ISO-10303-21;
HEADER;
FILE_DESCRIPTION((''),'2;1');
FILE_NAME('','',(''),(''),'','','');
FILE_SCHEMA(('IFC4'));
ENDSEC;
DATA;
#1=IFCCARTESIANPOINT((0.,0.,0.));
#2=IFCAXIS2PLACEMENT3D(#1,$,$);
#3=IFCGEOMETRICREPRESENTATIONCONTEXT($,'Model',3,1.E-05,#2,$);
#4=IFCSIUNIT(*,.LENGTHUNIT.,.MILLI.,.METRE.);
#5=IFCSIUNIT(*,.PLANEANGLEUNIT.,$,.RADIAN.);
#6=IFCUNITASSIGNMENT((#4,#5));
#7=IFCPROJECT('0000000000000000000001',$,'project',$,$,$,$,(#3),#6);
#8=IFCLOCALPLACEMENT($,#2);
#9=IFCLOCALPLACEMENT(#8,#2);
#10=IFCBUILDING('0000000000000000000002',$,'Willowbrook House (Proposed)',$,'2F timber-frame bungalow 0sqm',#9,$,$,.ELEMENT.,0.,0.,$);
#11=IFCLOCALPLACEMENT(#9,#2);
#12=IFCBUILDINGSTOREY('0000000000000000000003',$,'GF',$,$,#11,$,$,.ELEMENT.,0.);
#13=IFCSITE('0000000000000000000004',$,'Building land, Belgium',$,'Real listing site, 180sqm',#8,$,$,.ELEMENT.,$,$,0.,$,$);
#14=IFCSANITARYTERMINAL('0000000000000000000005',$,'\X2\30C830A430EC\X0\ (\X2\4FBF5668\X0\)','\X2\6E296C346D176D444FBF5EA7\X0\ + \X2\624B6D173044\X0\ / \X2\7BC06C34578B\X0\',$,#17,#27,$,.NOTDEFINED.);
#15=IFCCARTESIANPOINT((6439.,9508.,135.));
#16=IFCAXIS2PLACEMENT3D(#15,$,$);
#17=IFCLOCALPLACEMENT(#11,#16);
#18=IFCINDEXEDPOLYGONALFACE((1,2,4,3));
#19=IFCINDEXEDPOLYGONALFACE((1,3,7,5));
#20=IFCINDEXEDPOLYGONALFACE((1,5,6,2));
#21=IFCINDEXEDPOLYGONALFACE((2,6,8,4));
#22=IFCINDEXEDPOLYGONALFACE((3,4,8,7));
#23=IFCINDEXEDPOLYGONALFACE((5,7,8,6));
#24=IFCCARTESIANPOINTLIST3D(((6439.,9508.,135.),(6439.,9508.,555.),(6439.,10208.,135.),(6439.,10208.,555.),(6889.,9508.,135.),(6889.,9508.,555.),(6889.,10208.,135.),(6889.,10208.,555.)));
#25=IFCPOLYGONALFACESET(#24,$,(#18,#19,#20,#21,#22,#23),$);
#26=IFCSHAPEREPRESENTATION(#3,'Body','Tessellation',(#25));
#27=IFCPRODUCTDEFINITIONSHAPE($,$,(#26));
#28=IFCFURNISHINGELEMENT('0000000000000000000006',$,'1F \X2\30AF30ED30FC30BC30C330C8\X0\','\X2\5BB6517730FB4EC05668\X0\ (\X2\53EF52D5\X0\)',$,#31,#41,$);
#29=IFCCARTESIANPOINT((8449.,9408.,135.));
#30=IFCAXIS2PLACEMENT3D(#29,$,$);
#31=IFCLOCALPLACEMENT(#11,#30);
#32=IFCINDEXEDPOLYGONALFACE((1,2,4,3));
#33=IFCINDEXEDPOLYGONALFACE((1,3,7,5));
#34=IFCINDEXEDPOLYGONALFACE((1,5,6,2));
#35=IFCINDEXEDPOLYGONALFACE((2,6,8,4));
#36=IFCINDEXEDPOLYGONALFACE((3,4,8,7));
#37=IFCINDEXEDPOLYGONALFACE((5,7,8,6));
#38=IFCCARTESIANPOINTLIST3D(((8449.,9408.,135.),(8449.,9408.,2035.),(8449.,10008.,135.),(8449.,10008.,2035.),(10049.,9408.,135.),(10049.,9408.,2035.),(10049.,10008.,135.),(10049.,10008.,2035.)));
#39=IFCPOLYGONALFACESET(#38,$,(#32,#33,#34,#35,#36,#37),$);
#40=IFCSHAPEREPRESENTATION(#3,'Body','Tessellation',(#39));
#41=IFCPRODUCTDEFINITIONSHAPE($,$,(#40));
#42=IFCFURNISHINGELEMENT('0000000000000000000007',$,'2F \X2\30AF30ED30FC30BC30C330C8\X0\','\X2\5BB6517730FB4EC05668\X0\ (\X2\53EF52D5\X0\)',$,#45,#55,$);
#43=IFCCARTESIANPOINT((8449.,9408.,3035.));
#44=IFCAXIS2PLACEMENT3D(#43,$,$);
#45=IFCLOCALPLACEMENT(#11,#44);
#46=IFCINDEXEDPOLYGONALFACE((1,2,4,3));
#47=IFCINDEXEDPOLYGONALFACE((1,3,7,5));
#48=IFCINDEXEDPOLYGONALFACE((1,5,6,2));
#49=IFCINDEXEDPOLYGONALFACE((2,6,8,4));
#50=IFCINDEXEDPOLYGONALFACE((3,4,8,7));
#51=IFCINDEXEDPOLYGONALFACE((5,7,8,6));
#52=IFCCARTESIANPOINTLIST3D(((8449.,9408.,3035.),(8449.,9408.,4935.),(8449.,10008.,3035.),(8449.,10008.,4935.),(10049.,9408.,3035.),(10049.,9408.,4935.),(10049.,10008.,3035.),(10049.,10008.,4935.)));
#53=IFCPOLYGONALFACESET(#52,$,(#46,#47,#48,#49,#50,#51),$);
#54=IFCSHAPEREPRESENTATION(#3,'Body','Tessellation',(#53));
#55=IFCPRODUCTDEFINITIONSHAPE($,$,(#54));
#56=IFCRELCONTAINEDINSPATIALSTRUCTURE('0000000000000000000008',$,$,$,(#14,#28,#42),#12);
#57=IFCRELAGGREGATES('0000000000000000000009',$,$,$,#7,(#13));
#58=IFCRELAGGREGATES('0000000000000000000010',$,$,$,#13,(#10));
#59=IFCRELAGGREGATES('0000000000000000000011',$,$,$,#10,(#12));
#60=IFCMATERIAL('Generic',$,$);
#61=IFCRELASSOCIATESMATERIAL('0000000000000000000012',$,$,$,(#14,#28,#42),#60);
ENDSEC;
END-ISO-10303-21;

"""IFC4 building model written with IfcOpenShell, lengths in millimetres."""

from ifc_helpers import new_model, si_unit, frame, frame_2d, origin, place, context, project, spatial, rectangle, extrude, material, element, save


model = new_model("IFC4")

# Units and contexts
model_context = context("Model", 3, precision=1e-05, world=origin())
ifc_project = project(units=[si_unit("LENGTHUNIT", "METRE", prefix="MILLI"), si_unit("PLANEANGLEUNIT", "RADIAN")], contexts=[model_context])

# Site, building, storey
site_placement = place(None, origin())
site = spatial("IfcSite", under=ifc_project, at=site_placement, Name="Building land, Belgium", ObjectType="Real listing site, 180sqm", CompositionType="ELEMENT", RefElevation=0.0)
building_placement = place(site_placement, origin())
building = spatial("IfcBuilding", under=site, at=building_placement, Name="Willowbrook House (Proposed)", ObjectType="2F timber-frame bungalow 0sqm", CompositionType="ELEMENT", ElevationOfRefHeight=0.0, ElevationOfTerrain=0.0)
storey_placement = place(building_placement, origin())
storey = spatial("IfcBuildingStorey", under=building, at=storey_placement, Name="GF", CompositionType="ELEMENT", Elevation=0.0)

# Shared definitions
ifc_material_1 = material(Name="Generic")

# Sanitary terminal
sanitary_terminal_1_placement = place(storey_placement, frame((6439.0, 9508.0, 135.0)))
element("IfcSanitaryTerminal", 1, at=sanitary_terminal_1_placement, inside=storey, material=ifc_material_1, Name="トイレ (便器)", Description="温水洗浄便座 + 手洗い / 節水型", PredefinedType="NOTDEFINED", context=model_context, shape_type="SweptSolid", body=[
    extrude(rectangle(XDim=450.0, YDim=700.0, at=frame_2d((225.0, 350.0))), frame((6439.0, 9508.0, 135.0)), (0.0, 0.0, 1.0), 420.0),
])

# Furnishing elements
furnishing_1_placement = place(storey_placement, frame((8449.0, 9408.0, 135.0)))
element("IfcFurnishingElement", 2, at=furnishing_1_placement, inside=storey, material=ifc_material_1, Name="1F クローゼット", Description="家具・什器 (可動)", context=model_context, shape_type="SweptSolid", body=[
    extrude(rectangle(XDim=1600.0, YDim=600.0, at=frame_2d((800.0, 300.0))), frame((8449.0, 9408.0, 135.0)), (0.0, 0.0, 1.0), 1900.0),
])
furnishing_2_placement = place(storey_placement, frame((8449.0, 9408.0, 3035.0)))
element("IfcFurnishingElement", 3, at=furnishing_2_placement, inside=storey, material=ifc_material_1, Name="2F クローゼット", Description="家具・什器 (可動)", context=model_context, shape_type="SweptSolid", body=[
    extrude(rectangle(XDim=1600.0, YDim=600.0, at=frame_2d((800.0, 300.0))), frame((8449.0, 9408.0, 3035.0)), (0.0, 0.0, 1.0), 1900.0),
])

save(model, "model.ifc")
